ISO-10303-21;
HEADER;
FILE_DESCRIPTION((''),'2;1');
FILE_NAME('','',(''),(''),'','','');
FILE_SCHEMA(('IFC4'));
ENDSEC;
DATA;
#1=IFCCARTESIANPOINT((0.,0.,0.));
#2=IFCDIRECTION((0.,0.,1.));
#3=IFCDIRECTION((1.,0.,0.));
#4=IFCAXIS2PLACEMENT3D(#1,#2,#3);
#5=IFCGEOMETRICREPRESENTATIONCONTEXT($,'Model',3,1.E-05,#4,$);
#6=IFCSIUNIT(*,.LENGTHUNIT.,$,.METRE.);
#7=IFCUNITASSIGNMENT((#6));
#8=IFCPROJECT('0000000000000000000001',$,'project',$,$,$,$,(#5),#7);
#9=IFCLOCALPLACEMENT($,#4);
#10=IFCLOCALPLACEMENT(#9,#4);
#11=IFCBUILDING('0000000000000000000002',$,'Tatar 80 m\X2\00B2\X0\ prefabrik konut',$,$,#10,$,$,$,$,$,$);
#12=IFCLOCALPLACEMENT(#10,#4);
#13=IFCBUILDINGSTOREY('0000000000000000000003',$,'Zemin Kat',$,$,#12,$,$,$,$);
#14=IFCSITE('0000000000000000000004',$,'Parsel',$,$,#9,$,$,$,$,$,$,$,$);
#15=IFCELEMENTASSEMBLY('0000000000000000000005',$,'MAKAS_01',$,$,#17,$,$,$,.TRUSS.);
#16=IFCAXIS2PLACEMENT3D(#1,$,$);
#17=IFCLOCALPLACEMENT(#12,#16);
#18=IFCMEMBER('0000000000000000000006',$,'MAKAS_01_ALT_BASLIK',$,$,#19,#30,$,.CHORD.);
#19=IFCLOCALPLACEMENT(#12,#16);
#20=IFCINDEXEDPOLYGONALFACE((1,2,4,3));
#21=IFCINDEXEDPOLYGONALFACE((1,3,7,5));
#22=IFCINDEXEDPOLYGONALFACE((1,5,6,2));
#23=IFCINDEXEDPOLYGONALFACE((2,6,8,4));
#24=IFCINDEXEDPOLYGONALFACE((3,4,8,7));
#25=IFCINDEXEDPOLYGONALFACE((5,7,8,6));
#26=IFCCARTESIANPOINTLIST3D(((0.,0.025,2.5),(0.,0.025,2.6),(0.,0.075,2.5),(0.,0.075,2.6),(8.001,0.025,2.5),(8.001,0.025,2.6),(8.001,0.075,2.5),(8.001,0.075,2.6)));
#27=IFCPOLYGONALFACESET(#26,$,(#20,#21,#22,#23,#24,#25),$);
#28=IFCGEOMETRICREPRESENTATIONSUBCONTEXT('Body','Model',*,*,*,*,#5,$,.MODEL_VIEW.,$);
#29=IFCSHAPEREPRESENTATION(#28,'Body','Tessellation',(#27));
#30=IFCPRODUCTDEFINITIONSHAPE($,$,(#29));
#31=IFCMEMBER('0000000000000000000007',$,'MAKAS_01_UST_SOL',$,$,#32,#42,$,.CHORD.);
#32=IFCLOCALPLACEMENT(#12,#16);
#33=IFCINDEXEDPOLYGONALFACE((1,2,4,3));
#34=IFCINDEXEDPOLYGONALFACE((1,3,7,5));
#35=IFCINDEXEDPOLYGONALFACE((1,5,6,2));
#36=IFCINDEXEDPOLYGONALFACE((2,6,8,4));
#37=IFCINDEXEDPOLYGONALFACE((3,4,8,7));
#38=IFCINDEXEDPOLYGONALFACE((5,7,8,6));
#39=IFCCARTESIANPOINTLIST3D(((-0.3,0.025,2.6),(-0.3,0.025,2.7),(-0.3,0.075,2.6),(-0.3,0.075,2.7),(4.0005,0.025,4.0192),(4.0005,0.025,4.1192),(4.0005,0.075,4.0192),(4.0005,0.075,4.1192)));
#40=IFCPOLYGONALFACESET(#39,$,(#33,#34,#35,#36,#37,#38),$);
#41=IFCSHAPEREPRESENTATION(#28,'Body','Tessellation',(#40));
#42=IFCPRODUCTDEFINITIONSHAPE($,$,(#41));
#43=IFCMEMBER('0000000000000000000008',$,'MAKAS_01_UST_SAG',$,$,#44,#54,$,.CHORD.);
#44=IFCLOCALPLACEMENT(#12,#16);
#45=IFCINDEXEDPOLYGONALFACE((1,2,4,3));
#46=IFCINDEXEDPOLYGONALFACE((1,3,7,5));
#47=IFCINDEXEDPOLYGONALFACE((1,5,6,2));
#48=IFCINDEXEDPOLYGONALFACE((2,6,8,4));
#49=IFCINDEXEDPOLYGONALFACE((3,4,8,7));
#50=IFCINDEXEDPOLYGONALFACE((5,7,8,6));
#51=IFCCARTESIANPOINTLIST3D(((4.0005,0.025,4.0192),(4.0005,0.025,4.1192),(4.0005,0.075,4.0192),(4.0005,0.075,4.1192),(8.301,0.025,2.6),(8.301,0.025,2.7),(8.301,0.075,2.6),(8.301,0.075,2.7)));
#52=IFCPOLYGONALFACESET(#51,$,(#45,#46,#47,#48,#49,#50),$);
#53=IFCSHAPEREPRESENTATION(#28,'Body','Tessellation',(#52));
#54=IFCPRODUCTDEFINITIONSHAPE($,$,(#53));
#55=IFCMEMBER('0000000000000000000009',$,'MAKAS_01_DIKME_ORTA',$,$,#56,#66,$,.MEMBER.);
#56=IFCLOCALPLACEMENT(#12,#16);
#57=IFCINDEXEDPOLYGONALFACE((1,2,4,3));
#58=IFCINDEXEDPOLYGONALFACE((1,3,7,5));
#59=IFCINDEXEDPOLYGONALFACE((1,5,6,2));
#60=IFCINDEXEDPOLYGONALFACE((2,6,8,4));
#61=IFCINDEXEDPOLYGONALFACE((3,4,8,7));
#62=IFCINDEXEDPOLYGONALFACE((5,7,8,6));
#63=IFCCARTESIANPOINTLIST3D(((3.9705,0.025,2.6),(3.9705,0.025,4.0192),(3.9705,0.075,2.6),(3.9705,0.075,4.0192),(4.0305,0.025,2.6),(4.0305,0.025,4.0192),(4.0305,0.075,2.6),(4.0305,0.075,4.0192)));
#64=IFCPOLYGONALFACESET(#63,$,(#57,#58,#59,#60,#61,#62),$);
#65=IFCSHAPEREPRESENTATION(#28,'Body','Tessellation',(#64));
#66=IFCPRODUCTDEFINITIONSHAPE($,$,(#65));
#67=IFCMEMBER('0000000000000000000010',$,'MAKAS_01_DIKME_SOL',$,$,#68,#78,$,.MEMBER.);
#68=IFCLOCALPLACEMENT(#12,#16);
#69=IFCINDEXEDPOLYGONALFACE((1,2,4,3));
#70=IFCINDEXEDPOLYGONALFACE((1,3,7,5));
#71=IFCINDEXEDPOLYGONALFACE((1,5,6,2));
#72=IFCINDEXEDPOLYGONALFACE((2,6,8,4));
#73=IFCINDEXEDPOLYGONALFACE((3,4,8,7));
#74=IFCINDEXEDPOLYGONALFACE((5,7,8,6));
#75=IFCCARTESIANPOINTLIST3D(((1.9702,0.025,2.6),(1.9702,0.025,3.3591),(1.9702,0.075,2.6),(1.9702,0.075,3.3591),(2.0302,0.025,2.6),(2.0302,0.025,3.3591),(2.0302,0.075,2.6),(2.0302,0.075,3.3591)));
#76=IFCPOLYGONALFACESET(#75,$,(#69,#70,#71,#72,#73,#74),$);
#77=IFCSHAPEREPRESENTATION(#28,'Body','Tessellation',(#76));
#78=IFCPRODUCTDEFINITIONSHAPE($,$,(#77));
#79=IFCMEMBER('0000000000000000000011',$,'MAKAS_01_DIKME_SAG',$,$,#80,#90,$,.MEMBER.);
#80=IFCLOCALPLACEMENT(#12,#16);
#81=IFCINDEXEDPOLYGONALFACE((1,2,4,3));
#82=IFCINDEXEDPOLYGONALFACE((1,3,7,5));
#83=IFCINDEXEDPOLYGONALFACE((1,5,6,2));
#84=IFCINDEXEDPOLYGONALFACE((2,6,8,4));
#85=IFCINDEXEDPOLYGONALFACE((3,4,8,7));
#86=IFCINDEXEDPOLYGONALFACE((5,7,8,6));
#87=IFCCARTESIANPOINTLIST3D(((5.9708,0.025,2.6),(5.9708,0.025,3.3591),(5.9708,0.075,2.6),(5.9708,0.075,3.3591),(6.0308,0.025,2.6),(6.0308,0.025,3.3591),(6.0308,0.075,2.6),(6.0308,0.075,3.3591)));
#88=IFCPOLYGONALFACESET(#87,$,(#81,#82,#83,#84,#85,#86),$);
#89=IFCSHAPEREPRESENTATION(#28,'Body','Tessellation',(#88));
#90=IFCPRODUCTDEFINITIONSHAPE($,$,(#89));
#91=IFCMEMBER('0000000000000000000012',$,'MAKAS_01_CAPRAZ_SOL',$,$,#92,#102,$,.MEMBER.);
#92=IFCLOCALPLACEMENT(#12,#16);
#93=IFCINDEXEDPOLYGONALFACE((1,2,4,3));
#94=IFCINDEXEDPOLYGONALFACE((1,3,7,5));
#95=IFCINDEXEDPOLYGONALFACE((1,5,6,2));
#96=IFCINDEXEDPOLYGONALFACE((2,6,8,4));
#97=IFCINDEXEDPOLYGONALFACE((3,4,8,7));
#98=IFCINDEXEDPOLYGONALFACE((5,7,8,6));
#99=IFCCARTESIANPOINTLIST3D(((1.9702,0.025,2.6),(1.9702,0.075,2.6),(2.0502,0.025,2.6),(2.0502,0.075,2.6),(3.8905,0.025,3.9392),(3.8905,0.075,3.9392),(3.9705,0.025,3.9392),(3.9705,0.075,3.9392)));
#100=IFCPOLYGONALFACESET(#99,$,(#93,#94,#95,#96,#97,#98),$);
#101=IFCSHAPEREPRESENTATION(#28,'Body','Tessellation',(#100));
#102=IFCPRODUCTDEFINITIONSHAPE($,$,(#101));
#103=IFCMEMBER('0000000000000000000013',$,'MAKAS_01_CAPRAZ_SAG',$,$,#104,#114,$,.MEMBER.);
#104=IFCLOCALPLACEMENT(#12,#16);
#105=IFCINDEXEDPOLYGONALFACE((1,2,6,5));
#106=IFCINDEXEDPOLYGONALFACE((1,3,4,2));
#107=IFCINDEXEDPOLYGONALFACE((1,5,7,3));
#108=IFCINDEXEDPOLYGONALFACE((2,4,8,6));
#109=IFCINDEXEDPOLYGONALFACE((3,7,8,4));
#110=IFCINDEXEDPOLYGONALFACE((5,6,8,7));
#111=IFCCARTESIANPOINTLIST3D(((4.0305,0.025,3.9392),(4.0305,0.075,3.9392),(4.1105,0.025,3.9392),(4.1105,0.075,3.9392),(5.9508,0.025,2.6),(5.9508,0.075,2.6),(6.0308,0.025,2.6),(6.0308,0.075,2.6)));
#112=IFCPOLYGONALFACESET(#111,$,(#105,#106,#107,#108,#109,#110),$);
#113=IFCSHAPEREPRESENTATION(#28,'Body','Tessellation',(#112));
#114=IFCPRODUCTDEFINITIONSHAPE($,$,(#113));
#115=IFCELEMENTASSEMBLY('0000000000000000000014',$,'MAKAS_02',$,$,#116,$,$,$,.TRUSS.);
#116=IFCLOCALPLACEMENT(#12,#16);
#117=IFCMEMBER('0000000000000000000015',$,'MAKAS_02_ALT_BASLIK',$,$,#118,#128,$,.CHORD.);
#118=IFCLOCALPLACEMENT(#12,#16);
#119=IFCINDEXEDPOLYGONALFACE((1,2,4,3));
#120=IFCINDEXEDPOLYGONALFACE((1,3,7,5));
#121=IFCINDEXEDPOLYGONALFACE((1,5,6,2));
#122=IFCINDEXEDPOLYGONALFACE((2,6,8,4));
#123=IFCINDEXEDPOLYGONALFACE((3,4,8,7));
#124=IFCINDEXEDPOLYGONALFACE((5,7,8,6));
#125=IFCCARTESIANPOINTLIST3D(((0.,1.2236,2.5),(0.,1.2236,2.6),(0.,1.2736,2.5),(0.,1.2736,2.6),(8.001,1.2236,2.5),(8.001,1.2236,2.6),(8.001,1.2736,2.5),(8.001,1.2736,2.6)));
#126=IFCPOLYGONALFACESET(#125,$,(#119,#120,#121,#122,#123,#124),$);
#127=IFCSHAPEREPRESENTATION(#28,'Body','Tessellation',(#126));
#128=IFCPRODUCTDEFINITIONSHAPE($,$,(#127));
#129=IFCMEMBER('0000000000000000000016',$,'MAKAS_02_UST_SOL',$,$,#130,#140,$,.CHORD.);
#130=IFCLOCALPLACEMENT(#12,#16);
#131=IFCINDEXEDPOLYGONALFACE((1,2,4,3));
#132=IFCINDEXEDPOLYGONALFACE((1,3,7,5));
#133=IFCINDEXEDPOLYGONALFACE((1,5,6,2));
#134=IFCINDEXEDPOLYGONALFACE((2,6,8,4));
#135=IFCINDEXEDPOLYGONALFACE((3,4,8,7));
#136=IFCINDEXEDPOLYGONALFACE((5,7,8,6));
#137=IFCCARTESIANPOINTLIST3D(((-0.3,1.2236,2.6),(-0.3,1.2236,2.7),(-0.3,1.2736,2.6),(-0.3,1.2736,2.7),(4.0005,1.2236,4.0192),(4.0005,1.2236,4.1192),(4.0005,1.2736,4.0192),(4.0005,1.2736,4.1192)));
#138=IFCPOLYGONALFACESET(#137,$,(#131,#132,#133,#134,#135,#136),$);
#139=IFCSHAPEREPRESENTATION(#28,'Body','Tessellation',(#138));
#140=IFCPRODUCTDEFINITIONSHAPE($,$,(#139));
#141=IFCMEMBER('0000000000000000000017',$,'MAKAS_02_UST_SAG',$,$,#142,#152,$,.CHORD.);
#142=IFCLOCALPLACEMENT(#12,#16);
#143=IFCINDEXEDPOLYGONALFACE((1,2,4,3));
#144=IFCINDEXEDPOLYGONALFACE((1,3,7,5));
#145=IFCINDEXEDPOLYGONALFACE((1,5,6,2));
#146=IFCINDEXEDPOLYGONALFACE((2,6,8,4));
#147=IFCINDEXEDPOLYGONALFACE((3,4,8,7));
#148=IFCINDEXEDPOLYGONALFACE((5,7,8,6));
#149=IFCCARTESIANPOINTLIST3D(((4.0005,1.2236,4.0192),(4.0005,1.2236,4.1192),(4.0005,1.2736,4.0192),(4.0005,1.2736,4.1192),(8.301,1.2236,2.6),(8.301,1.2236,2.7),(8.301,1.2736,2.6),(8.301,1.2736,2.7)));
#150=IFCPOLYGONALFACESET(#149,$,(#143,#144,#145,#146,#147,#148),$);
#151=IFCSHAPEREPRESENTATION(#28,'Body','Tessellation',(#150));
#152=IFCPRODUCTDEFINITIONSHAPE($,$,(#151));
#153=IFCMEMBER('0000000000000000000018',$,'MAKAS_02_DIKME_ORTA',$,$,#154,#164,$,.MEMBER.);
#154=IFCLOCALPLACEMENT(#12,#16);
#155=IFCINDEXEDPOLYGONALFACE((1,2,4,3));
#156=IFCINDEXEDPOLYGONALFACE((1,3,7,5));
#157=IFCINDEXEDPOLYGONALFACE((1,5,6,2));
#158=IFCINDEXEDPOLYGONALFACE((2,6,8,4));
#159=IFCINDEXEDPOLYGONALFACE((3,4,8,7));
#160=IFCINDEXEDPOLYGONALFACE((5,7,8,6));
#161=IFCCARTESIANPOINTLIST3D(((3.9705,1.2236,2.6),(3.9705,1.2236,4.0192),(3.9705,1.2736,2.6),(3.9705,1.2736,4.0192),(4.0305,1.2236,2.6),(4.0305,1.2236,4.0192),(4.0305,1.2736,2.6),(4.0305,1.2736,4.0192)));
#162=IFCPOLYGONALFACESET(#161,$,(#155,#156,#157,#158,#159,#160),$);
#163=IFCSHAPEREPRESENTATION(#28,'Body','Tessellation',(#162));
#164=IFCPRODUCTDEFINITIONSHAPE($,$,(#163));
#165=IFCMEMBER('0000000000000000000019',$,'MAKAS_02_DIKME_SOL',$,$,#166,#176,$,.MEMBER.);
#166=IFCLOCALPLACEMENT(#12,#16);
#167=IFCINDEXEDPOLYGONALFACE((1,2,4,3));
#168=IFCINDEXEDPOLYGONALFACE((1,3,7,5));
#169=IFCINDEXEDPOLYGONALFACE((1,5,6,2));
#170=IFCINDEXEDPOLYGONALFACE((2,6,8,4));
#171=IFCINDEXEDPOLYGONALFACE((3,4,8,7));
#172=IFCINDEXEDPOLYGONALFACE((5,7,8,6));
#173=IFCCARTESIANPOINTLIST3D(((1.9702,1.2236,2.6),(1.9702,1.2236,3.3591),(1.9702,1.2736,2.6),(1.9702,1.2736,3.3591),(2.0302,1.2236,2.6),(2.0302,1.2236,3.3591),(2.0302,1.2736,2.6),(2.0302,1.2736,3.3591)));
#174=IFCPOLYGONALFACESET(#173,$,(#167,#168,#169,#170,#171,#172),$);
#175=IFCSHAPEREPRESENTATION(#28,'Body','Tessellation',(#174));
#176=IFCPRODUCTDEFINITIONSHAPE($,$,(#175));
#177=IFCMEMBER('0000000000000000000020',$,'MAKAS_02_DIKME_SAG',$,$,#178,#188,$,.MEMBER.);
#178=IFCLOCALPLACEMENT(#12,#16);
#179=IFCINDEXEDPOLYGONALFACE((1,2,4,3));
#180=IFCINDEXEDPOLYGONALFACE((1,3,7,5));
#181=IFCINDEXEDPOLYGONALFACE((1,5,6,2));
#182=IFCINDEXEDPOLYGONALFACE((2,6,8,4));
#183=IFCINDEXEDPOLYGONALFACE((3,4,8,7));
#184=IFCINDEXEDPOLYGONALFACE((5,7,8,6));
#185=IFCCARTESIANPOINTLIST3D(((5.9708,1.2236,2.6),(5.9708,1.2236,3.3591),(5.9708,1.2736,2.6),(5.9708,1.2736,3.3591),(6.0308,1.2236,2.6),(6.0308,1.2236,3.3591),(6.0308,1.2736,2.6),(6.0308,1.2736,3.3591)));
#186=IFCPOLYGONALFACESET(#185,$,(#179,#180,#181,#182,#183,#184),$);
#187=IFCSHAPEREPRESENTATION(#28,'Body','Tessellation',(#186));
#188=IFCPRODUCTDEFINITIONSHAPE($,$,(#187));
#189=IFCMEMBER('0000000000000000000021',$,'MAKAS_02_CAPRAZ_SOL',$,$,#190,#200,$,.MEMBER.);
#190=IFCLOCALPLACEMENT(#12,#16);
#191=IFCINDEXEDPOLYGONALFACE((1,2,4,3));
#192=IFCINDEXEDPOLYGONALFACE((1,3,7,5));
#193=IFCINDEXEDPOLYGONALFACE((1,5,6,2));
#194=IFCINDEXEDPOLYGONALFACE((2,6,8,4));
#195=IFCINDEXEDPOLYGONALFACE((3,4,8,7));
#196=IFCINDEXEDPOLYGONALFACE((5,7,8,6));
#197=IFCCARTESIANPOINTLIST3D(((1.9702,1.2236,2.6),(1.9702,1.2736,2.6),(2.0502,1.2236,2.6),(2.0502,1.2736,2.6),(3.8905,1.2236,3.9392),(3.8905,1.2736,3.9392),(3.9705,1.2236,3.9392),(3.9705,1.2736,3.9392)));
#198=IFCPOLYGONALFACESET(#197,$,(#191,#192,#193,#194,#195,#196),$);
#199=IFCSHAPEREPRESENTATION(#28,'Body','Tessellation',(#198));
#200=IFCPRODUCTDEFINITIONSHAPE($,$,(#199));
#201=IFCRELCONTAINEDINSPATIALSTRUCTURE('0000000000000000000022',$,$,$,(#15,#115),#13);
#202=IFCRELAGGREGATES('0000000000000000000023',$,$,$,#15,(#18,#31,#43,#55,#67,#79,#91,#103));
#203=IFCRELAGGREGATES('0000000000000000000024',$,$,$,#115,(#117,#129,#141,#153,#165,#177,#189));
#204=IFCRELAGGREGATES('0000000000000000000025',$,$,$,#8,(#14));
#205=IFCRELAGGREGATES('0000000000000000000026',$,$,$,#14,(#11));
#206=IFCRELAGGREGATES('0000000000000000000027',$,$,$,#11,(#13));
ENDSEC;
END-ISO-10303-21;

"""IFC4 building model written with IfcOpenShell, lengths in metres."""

from ifc_helpers import new_model, si_unit, frame, origin_with_axes, place, context, subcontext, project, spatial, line, indexed_curve, outline, extrude, element, aggregate, save


model = new_model("IFC4")

# Units and contexts
model_context = context("Model", 3, precision=1e-05, world=origin_with_axes())
body_context = subcontext(model_context, "Body", "Model", "MODEL_VIEW")
ifc_project = project(units=[si_unit("LENGTHUNIT", "METRE")], contexts=[model_context])

# Site, building, storey
site_placement = place(None, origin_with_axes())
site = spatial("IfcSite", under=ifc_project, at=site_placement, Name="Parsel")
building_placement = place(site_placement, origin_with_axes())
building = spatial("IfcBuilding", under=site, at=building_placement, Name="Tatar 80 m² prefabrik konut")
storey_placement = place(building_placement, origin_with_axes())
storey = spatial("IfcBuildingStorey", under=building, at=storey_placement, Name="Zemin Kat")

# Element assemblies, members
assembly_1_placement = place(storey_placement, origin_with_axes())
assembly_1 = element("IfcElementAssembly", 1, at=assembly_1_placement, inside=storey, Name="MAKAS_01", PredefinedType="TRUSS")
member_1_placement = place(assembly_1_placement, origin_with_axes())
member_1 = element("IfcMember", 2, at=member_1_placement, Name="MAKAS_01_ALT_BASLIK", PredefinedType="CHORD", context=body_context, shape_type="SweptSolid", body=[
    extrude(outline(indexed_curve([(0.0, 2.5), (8.001, 2.5), (8.001, 2.6), (0.0, 2.6)], segments=[line(1, 2, 3, 4, 1)])), frame((0.0, 0.075, 0.0), z_axis=(0.0, -1.0, 0.0), x_axis=(1.0, 0.0, 0.0)), (0.0, 0.0, 1.0), 0.05),
])
member_2_placement = place(assembly_1_placement, origin_with_axes())
member_2 = element("IfcMember", 3, at=member_2_placement, Name="MAKAS_01_UST_SOL", PredefinedType="CHORD", context=body_context, shape_type="SweptSolid", body=[
    extrude(outline(indexed_curve([(-0.3, 2.6), (4.0005, 4.0192), (4.0005, 4.1192), (-0.3, 2.7)], segments=[line(1, 2, 3, 4, 1)])), frame((0.0, 0.075, 0.0), z_axis=(0.0, -1.0, 0.0), x_axis=(1.0, 0.0, 0.0)), (0.0, 0.0, 1.0), 0.05),
])
member_3_placement = place(assembly_1_placement, origin_with_axes())
member_3 = element("IfcMember", 4, at=member_3_placement, Name="MAKAS_01_UST_SAG", PredefinedType="CHORD", context=body_context, shape_type="SweptSolid", body=[
    extrude(outline(indexed_curve([(4.0005, 4.0192), (8.301, 2.6), (8.301, 2.7), (4.0005, 4.1192)], segments=[line(1, 2, 3, 4, 1)])), frame((0.0, 0.075, 0.0), z_axis=(0.0, -1.0, 0.0), x_axis=(1.0, 0.0, 0.0)), (0.0, 0.0, 1.0), 0.05),
])
member_4_placement = place(assembly_1_placement, origin_with_axes())
member_4 = element("IfcMember", 5, at=member_4_placement, Name="MAKAS_01_DIKME_ORTA", PredefinedType="MEMBER", context=body_context, shape_type="SweptSolid", body=[
    extrude(outline(indexed_curve([(3.9705, 2.6), (4.0305, 2.6), (4.0305, 4.0192), (3.9705, 4.0192)], segments=[line(1, 2, 3, 4, 1)])), frame((0.0, 0.075, 0.0), z_axis=(0.0, -1.0, 0.0), x_axis=(1.0, 0.0, 0.0)), (0.0, 0.0, 1.0), 0.05),
])
member_5_placement = place(assembly_1_placement, origin_with_axes())
member_5 = element("IfcMember", 6, at=member_5_placement, Name="MAKAS_01_DIKME_SOL", PredefinedType="MEMBER", context=body_context, shape_type="SweptSolid", body=[
    extrude(outline(indexed_curve([(1.9703, 2.6), (2.0303, 2.6), (2.0303, 3.3591), (1.9703, 3.3591)], segments=[line(1, 2, 3, 4, 1)])), frame((0.0, 0.075, 0.0), z_axis=(0.0, -1.0, 0.0), x_axis=(1.0, 0.0, 0.0)), (0.0, 0.0, 1.0), 0.05),
])
member_6_placement = place(assembly_1_placement, origin_with_axes())
member_6 = element("IfcMember", 7, at=member_6_placement, Name="MAKAS_01_DIKME_SAG", PredefinedType="MEMBER", context=body_context, shape_type="SweptSolid", body=[
    extrude(outline(indexed_curve([(5.9708, 2.6), (6.0308, 2.6), (6.0308, 3.3591), (5.9708, 3.3591)], segments=[line(1, 2, 3, 4, 1)])), frame((0.0, 0.075, 0.0), z_axis=(0.0, -1.0, 0.0), x_axis=(1.0, 0.0, 0.0)), (0.0, 0.0, 1.0), 0.05),
])
member_7_placement = place(assembly_1_placement, origin_with_axes())
member_7 = element("IfcMember", 8, at=member_7_placement, Name="MAKAS_01_CAPRAZ_SOL", PredefinedType="MEMBER", context=body_context, shape_type="SweptSolid", body=[
    extrude(outline(indexed_curve([(1.9703, 2.6), (2.0503, 2.6), (3.9705, 3.9392), (3.8905, 3.9392)], segments=[line(1, 2, 3, 4, 1)])), frame((0.0, 0.075, 0.0), z_axis=(0.0, -1.0, 0.0), x_axis=(1.0, 0.0, 0.0)), (0.0, 0.0, 1.0), 0.05),
])
member_8_placement = place(assembly_1_placement, origin_with_axes())
member_8 = element("IfcMember", 9, at=member_8_placement, Name="MAKAS_01_CAPRAZ_SAG", PredefinedType="MEMBER", context=body_context, shape_type="SweptSolid", body=[
    extrude(outline(indexed_curve([(5.9508, 2.6), (6.0308, 2.6), (4.1105, 3.9392), (4.0305, 3.9392)], segments=[line(1, 2, 3, 4, 1)])), frame((0.0, 0.075, 0.0), z_axis=(0.0, -1.0, 0.0), x_axis=(1.0, 0.0, 0.0)), (0.0, 0.0, 1.0), 0.05),
])
aggregate(assembly_1, [member_1, member_2, member_3, member_4, member_5, member_6, member_7, member_8])
assembly_2_placement = place(storey_placement, origin_with_axes())
assembly_2 = element("IfcElementAssembly", 10, at=assembly_2_placement, inside=storey, Name="MAKAS_02", PredefinedType="TRUSS")
member_9_placement = place(assembly_2_placement, origin_with_axes())
member_9 = element("IfcMember", 11, at=member_9_placement, Name="MAKAS_02_ALT_BASLIK", PredefinedType="CHORD", context=body_context, shape_type="SweptSolid", body=[
    extrude(outline(indexed_curve([(0.0, 2.5), (8.001, 2.5), (8.001, 2.6), (0.0, 2.6)], segments=[line(1, 2, 3, 4, 1)])), frame((0.0, 1.2736, 0.0), z_axis=(0.0, -1.0, 0.0), x_axis=(1.0, 0.0, 0.0)), (0.0, 0.0, 1.0), 0.05),
])
member_10_placement = place(assembly_2_placement, origin_with_axes())
member_10 = element("IfcMember", 12, at=member_10_placement, Name="MAKAS_02_UST_SOL", PredefinedType="CHORD", context=body_context, shape_type="SweptSolid", body=[
    extrude(outline(indexed_curve([(-0.3, 2.6), (4.0005, 4.0192), (4.0005, 4.1192), (-0.3, 2.7)], segments=[line(1, 2, 3, 4, 1)])), frame((0.0, 1.2736, 0.0), z_axis=(0.0, -1.0, 0.0), x_axis=(1.0, 0.0, 0.0)), (0.0, 0.0, 1.0), 0.05),
])
member_11_placement = place(assembly_2_placement, origin_with_axes())
member_11 = element("IfcMember", 13, at=member_11_placement, Name="MAKAS_02_UST_SAG", PredefinedType="CHORD", context=body_context, shape_type="SweptSolid", body=[
    extrude(outline(indexed_curve([(4.0005, 4.0192), (8.301, 2.6), (8.301, 2.7), (4.0005, 4.1192)], segments=[line(1, 2, 3, 4, 1)])), frame((0.0, 1.2736, 0.0), z_axis=(0.0, -1.0, 0.0), x_axis=(1.0, 0.0, 0.0)), (0.0, 0.0, 1.0), 0.05),
])
member_12_placement = place(assembly_2_placement, origin_with_axes())
member_12 = element("IfcMember", 14, at=member_12_placement, Name="MAKAS_02_DIKME_ORTA", PredefinedType="MEMBER", context=body_context, shape_type="SweptSolid", body=[
    extrude(outline(indexed_curve([(3.9705, 2.6), (4.0305, 2.6), (4.0305, 4.0192), (3.9705, 4.0192)], segments=[line(1, 2, 3, 4, 1)])), frame((0.0, 1.2736, 0.0), z_axis=(0.0, -1.0, 0.0), x_axis=(1.0, 0.0, 0.0)), (0.0, 0.0, 1.0), 0.05),
])
member_13_placement = place(assembly_2_placement, origin_with_axes())
member_13 = element("IfcMember", 15, at=member_13_placement, Name="MAKAS_02_DIKME_SOL", PredefinedType="MEMBER", context=body_context, shape_type="SweptSolid", body=[
    extrude(outline(indexed_curve([(1.9703, 2.6), (2.0303, 2.6), (2.0303, 3.3591), (1.9703, 3.3591)], segments=[line(1, 2, 3, 4, 1)])), frame((0.0, 1.2736, 0.0), z_axis=(0.0, -1.0, 0.0), x_axis=(1.0, 0.0, 0.0)), (0.0, 0.0, 1.0), 0.05),
])
member_14_placement = place(assembly_2_placement, origin_with_axes())
member_14 = element("IfcMember", 16, at=member_14_placement, Name="MAKAS_02_DIKME_SAG", PredefinedType="MEMBER", context=body_context, shape_type="SweptSolid", body=[
    extrude(outline(indexed_curve([(5.9708, 2.6), (6.0308, 2.6), (6.0308, 3.3591), (5.9708, 3.3591)], segments=[line(1, 2, 3, 4, 1)])), frame((0.0, 1.2736, 0.0), z_axis=(0.0, -1.0, 0.0), x_axis=(1.0, 0.0, 0.0)), (0.0, 0.0, 1.0), 0.05),
])
member_15_placement = place(assembly_2_placement, origin_with_axes())
member_15 = element("IfcMember", 17, at=member_15_placement, Name="MAKAS_02_CAPRAZ_SOL", PredefinedType="MEMBER", context=body_context, shape_type="SweptSolid", body=[
    extrude(outline(indexed_curve([(1.9703, 2.6), (2.0503, 2.6), (3.9705, 3.9392), (3.8905, 3.9392)], segments=[line(1, 2, 3, 4, 1)])), frame((0.0, 1.2736, 0.0), z_axis=(0.0, -1.0, 0.0), x_axis=(1.0, 0.0, 0.0)), (0.0, 0.0, 1.0), 0.05),
])
aggregate(assembly_2, [member_9, member_10, member_11, member_12, member_13, member_14, member_15])

save(model, "model.ifc")
